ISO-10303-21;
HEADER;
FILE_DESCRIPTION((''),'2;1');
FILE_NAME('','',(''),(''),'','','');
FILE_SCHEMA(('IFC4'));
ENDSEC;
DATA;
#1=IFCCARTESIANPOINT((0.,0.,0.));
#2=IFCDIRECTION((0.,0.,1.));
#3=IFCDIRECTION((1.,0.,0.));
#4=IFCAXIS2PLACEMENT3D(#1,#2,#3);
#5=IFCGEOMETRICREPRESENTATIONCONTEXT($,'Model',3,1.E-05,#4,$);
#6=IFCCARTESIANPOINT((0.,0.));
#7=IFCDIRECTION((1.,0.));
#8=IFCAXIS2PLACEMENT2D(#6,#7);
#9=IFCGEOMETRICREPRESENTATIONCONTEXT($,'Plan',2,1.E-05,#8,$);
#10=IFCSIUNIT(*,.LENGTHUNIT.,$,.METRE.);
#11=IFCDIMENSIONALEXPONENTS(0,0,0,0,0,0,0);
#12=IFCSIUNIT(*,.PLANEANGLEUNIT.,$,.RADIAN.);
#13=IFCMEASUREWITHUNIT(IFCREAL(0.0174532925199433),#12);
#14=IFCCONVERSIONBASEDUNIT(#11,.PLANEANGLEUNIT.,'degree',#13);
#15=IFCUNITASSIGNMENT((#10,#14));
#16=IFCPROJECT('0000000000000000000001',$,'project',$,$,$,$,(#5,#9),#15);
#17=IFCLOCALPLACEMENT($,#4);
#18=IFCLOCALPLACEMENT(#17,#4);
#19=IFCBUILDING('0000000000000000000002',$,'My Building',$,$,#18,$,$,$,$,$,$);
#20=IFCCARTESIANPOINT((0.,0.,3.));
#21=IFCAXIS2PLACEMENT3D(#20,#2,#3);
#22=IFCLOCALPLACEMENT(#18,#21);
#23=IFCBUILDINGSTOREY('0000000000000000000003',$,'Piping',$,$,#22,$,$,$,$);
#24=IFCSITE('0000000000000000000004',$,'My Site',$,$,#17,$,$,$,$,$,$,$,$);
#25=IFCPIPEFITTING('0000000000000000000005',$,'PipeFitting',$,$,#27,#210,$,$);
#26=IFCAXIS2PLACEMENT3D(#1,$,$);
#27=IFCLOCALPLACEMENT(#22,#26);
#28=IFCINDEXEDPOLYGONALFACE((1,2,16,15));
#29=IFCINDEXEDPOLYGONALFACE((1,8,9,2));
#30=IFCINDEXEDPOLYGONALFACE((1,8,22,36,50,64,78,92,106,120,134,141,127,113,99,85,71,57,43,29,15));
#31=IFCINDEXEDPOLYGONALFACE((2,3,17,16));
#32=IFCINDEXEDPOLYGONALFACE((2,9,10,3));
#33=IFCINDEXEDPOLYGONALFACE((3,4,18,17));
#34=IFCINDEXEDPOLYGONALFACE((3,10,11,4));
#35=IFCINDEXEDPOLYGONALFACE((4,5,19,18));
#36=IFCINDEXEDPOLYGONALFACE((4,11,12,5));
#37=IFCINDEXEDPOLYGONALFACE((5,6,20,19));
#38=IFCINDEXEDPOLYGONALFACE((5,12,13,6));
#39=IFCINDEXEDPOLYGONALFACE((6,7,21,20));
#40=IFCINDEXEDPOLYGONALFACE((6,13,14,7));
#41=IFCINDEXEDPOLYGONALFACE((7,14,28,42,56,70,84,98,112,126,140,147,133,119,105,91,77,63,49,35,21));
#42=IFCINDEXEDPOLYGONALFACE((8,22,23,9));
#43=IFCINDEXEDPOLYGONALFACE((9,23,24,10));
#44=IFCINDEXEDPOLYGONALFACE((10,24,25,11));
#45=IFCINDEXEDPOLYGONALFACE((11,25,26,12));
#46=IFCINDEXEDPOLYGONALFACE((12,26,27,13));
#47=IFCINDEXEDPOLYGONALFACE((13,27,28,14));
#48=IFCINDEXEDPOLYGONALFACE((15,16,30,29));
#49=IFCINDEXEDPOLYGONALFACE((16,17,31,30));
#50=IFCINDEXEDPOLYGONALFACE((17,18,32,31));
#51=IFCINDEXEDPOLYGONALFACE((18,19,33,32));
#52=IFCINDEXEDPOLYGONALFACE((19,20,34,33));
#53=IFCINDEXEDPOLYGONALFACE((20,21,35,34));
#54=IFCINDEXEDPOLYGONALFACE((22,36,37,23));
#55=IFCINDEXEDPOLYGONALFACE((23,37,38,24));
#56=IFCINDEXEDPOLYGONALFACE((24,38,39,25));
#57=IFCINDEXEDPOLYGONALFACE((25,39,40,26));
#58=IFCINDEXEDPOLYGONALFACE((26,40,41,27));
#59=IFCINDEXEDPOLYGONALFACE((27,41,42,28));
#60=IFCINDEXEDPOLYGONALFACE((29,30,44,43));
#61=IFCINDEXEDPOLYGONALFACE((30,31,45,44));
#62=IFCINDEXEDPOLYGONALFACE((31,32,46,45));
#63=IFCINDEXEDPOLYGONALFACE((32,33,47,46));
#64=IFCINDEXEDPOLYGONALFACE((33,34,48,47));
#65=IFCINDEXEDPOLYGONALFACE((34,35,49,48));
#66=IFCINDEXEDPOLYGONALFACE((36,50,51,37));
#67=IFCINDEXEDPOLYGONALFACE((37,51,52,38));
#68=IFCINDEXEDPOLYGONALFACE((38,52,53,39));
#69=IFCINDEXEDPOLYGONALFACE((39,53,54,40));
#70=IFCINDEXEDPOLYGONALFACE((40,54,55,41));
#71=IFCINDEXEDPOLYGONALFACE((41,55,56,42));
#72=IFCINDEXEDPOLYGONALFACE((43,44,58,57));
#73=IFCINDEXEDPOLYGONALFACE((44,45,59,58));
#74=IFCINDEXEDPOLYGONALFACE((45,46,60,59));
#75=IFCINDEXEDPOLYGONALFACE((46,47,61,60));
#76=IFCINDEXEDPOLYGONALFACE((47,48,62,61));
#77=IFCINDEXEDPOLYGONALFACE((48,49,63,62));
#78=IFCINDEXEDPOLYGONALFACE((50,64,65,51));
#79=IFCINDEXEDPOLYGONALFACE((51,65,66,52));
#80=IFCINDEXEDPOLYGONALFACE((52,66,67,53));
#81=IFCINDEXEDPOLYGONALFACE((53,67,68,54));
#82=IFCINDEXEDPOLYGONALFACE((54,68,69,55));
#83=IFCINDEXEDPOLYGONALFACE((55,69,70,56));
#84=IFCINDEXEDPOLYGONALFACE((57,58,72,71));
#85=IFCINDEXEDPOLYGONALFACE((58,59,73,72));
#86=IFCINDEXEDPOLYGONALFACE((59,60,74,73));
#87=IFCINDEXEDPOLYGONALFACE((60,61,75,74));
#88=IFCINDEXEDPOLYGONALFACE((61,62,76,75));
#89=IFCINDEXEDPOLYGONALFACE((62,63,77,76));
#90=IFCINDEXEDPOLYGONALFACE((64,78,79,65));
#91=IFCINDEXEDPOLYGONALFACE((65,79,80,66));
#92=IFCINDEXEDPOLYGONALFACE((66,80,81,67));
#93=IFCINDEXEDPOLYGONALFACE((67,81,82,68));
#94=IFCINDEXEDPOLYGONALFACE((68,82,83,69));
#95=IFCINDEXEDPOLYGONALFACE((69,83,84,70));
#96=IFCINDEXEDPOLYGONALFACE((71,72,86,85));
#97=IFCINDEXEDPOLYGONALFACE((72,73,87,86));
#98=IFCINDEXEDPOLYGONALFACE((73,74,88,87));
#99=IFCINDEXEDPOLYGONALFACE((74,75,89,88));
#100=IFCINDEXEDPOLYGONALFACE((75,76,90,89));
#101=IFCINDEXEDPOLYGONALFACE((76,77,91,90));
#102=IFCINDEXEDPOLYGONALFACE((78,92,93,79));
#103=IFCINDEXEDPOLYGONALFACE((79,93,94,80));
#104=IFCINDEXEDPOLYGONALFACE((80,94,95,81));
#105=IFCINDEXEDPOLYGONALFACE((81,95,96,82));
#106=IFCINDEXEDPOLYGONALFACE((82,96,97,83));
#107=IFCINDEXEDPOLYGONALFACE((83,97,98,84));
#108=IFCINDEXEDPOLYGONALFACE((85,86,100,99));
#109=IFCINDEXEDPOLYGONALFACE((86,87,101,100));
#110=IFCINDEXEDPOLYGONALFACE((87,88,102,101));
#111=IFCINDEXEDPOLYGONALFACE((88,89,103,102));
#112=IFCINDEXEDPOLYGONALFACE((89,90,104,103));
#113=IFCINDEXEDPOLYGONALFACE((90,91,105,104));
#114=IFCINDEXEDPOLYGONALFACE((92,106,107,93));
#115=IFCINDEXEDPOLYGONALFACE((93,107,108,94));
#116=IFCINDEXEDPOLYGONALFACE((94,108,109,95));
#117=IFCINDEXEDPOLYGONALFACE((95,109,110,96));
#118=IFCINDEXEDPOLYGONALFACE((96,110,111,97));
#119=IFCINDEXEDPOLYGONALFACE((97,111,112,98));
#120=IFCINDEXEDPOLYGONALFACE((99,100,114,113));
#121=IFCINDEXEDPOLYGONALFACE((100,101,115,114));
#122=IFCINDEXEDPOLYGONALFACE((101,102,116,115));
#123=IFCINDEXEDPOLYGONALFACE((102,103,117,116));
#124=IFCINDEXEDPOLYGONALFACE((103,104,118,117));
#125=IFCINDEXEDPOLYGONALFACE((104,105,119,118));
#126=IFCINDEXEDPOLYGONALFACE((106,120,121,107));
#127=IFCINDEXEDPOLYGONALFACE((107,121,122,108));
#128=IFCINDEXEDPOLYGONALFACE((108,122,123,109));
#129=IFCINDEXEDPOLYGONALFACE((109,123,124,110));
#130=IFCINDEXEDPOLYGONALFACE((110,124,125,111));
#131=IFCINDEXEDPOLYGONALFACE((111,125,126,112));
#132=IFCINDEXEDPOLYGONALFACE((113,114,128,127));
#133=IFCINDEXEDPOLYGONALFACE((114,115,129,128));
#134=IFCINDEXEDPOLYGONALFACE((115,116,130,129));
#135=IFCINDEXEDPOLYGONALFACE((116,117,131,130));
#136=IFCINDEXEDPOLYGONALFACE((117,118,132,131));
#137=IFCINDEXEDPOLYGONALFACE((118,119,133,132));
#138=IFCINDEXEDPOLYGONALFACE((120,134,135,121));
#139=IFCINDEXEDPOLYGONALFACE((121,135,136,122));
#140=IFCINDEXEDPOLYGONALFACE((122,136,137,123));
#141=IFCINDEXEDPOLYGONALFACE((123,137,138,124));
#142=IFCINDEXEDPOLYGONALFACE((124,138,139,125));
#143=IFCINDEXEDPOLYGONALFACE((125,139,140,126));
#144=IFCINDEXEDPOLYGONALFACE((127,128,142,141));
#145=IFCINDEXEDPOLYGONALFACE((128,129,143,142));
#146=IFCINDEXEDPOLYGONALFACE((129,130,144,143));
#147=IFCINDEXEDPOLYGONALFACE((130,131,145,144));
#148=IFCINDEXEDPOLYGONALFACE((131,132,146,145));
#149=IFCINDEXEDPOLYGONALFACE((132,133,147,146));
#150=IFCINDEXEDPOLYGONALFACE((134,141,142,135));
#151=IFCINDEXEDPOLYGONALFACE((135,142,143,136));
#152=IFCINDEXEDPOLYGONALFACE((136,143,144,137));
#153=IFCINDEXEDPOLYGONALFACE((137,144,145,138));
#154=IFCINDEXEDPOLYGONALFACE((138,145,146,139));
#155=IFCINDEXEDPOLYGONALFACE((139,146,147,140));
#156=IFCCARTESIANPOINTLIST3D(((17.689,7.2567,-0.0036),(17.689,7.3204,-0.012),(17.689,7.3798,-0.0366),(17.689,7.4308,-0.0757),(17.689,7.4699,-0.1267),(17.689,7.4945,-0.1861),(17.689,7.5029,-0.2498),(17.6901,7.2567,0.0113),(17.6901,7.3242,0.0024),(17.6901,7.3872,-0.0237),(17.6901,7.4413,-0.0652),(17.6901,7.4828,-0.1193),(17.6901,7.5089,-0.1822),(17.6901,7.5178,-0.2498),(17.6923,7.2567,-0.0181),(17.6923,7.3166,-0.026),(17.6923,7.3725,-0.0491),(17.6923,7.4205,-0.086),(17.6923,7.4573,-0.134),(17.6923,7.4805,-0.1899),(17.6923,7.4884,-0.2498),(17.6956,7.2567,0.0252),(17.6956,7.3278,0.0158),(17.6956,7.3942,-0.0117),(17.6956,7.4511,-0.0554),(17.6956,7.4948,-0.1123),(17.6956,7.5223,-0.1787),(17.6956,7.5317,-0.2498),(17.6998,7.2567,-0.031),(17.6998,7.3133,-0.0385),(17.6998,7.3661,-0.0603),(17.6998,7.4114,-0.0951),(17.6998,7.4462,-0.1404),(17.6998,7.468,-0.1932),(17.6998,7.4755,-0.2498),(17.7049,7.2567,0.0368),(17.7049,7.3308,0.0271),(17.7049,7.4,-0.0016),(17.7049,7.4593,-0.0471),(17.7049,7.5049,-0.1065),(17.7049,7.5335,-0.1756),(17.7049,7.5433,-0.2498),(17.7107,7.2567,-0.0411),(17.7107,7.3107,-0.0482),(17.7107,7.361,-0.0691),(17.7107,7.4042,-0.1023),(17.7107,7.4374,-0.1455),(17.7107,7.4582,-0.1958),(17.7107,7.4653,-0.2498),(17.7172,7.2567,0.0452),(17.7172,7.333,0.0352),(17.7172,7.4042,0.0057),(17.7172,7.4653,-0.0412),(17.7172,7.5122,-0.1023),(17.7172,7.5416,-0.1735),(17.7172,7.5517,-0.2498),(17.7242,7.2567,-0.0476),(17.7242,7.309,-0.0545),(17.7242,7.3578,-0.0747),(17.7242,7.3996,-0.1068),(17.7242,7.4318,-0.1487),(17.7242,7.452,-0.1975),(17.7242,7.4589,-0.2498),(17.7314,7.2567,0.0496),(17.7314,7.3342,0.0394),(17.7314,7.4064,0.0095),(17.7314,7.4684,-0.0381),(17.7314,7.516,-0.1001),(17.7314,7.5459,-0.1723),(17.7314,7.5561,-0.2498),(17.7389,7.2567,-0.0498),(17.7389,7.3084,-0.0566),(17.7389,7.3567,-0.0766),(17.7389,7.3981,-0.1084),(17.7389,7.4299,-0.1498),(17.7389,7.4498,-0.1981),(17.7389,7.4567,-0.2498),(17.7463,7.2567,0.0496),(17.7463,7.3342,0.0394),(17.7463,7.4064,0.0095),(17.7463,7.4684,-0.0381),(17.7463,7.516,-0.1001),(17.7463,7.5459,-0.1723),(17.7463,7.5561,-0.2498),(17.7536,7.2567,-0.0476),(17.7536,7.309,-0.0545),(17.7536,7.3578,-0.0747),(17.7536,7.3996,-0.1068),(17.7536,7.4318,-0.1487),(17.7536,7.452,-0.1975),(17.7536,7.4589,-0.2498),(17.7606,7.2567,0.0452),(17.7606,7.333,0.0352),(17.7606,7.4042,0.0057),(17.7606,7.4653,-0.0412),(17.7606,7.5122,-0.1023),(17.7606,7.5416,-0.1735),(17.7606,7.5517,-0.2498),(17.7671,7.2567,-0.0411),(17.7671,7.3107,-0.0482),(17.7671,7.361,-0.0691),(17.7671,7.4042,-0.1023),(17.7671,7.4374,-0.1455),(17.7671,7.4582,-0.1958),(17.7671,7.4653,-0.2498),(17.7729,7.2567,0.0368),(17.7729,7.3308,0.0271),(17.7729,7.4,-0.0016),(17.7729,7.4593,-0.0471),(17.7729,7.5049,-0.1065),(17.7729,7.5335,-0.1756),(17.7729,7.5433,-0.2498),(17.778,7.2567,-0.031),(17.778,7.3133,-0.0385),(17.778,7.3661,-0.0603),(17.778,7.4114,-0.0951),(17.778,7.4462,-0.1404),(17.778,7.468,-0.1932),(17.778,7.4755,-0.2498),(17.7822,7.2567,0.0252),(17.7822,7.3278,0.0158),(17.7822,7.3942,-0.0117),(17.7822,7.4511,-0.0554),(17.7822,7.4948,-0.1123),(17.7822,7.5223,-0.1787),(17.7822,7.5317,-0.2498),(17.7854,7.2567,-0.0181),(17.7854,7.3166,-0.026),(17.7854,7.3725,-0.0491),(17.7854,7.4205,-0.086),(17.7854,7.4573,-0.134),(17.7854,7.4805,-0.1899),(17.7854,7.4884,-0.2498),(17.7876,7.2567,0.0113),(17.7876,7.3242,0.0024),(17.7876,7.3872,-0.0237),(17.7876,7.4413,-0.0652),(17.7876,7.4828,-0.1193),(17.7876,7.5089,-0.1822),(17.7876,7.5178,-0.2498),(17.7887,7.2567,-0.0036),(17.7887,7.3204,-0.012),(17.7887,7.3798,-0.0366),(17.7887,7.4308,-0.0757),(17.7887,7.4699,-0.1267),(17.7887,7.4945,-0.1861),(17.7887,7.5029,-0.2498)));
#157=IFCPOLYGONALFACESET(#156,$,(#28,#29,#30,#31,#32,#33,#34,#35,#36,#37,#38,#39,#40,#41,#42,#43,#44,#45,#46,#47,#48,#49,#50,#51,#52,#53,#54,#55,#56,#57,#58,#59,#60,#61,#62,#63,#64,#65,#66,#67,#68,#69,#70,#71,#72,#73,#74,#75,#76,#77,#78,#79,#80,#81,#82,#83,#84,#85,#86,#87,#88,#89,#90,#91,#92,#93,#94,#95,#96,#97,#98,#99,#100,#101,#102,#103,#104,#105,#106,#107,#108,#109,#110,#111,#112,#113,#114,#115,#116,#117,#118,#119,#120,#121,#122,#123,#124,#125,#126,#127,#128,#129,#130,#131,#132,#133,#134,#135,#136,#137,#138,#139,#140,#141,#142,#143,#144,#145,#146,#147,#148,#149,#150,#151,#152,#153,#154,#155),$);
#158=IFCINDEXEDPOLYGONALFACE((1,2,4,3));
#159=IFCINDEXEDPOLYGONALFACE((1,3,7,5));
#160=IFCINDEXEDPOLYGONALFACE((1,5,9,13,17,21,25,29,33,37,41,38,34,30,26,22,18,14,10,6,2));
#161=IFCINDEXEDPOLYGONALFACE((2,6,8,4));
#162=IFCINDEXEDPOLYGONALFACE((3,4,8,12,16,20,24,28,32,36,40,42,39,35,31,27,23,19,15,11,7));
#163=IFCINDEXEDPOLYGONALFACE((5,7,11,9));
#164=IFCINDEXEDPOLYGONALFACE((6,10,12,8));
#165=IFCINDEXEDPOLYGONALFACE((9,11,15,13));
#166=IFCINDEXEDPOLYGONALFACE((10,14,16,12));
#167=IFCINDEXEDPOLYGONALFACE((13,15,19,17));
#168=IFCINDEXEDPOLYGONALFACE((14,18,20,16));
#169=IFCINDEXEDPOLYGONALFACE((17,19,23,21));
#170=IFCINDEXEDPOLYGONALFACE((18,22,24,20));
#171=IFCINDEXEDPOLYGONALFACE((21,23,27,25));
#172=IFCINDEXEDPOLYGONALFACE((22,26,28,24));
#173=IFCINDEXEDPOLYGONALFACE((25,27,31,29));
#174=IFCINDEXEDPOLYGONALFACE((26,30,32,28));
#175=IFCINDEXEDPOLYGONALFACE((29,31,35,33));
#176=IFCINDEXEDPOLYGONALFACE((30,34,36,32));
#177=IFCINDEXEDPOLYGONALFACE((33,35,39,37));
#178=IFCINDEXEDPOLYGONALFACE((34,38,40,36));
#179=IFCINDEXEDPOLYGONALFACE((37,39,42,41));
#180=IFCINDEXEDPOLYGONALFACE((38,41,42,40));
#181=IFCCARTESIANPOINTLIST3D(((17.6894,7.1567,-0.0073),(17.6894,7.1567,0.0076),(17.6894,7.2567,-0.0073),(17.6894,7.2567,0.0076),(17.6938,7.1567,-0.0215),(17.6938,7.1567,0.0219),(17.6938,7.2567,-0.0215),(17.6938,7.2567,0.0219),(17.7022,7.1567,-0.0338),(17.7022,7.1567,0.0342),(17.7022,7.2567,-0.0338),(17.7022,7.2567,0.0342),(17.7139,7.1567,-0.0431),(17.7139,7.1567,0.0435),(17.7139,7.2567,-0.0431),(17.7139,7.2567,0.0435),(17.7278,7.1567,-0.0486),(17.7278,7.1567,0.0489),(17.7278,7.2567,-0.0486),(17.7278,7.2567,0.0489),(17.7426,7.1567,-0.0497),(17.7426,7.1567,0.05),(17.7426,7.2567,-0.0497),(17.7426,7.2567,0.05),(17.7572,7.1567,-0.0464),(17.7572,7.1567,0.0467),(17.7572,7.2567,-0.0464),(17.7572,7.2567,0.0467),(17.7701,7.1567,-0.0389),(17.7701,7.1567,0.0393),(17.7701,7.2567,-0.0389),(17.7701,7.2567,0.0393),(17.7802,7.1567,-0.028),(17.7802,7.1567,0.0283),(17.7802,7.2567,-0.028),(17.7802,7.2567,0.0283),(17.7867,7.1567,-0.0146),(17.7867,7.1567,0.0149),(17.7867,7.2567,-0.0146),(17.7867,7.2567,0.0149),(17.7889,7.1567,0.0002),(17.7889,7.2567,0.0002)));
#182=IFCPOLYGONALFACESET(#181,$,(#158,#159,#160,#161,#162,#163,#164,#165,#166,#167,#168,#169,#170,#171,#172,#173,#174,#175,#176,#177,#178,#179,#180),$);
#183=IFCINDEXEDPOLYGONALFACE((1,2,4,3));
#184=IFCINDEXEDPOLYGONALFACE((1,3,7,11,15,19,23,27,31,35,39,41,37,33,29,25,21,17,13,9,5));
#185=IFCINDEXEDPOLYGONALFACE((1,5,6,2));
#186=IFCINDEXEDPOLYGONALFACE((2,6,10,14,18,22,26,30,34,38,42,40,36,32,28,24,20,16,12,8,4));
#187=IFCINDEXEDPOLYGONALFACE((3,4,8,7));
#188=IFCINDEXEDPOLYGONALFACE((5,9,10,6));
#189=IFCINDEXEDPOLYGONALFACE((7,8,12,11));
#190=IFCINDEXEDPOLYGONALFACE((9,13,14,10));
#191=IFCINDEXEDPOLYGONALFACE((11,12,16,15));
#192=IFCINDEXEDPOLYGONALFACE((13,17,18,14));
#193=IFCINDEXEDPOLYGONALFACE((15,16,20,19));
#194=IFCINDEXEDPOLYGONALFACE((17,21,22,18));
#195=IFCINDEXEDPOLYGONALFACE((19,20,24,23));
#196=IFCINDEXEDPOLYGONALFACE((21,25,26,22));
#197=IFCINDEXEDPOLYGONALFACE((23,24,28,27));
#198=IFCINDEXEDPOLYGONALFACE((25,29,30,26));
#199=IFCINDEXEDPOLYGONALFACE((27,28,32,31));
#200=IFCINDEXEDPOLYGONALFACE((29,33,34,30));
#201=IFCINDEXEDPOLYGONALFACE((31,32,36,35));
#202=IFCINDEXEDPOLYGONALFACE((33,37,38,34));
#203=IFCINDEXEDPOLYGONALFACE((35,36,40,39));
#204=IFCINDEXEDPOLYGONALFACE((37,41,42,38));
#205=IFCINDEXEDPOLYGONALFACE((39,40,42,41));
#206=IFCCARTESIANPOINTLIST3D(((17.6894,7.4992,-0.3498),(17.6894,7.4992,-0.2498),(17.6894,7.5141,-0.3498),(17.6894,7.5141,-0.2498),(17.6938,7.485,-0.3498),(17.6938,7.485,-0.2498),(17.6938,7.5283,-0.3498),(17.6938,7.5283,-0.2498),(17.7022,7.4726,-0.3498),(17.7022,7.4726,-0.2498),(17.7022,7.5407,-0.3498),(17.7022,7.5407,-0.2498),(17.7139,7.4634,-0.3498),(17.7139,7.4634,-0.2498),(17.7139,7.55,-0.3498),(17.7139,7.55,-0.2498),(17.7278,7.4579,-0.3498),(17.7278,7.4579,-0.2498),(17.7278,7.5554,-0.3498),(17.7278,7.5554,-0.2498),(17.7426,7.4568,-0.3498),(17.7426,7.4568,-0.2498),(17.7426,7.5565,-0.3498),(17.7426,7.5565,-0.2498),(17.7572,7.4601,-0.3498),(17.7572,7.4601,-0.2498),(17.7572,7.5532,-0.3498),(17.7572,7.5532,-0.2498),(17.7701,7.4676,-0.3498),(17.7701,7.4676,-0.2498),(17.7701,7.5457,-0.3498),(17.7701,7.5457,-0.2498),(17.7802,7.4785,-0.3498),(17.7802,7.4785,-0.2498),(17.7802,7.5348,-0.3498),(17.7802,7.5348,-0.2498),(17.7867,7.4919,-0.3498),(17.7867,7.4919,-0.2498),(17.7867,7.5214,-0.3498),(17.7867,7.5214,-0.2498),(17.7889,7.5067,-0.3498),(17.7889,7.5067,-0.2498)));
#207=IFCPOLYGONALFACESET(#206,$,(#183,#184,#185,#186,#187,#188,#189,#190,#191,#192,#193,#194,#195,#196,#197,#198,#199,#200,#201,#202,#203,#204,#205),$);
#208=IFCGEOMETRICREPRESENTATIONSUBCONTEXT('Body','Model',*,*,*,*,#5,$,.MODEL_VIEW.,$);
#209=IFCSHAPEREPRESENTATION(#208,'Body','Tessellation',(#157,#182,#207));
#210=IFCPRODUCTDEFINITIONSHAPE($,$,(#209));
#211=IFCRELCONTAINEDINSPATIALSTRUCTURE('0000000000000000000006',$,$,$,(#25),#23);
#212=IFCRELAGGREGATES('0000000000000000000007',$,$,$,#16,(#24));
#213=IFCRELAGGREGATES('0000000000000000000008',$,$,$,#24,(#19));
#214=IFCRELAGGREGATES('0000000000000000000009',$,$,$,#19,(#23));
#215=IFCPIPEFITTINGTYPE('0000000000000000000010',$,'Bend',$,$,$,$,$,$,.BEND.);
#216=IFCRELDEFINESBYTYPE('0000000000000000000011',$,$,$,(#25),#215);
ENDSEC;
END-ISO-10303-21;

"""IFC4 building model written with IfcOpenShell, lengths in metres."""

from ifc_helpers import new_model, entity, si_unit, converted_unit, frame, origin_with_axes, origin_2d_with_axis, place, context, subcontext, project, spatial, circle, extrude, source, transform, mapped, type_object, type_shapes, element, save


model = new_model("IFC4")

# Units and contexts
model_context = context("Model", 3, precision=1e-05, world=origin_with_axes())
plan_context = context("Plan", 2, precision=1e-05, world=origin_2d_with_axis())
body_context = subcontext(model_context, "Body", "Model", "MODEL_VIEW")
ifc_project = project(units=[si_unit("LENGTHUNIT", "METRE"), converted_unit("PLANEANGLEUNIT", "degree", entity("IfcReal", 0.0174532925199433), si_unit("PLANEANGLEUNIT", "RADIAN"), dimensions=[0, 0, 0, 0, 0, 0, 0])], contexts=[model_context, plan_context])

# Site, building, storey
site_placement = place(None, origin_with_axes())
site = spatial("IfcSite", under=ifc_project, at=site_placement, Name="My Site")
building_placement = place(site_placement, origin_with_axes())
building = spatial("IfcBuilding", under=site, at=building_placement, Name="My Building")
storey_placement = place(building_placement, frame((0.0, 0.0, 3.0), z_axis=(0.0, 0.0, 1.0), x_axis=(1.0, 0.0, 0.0)))
storey = spatial("IfcBuildingStorey", under=building, at=storey_placement, Name="Piping")

# Pipe fitting
pipe_fitting_type = type_object("IfcPipeFittingType", Name="Bend", PredefinedType="BEND")
shared_shape = source(origin_with_axes(), body_context, "Body", "SolidModel", [
    entity("IfcSweptDiskSolid", entity("IfcIndexedPolyCurve", entity("IfcCartesianPointList3D", [[0.0, 0.0, -0.1], [0.0, -0.0732, -0.2768], [0.0, -0.25, -0.35]]), [entity("IfcArcIndex", [1, 2, 3])]), 0.05),
    extrude(circle(Radius=0.05), origin_with_axes(), (0.0, 0.0, -1.0), 0.1),
    extrude(circle(Radius=0.05), frame((0.0, -0.25, -0.35), z_axis=(0.0, -1.0, 0.0), x_axis=(1.0, 0.0, 0.0)), (0.0, 0.0, 1.0), 0.1),
])
type_shapes(pipe_fitting_type, [shared_shape])
for number, where, z_axis, x_axis, name in (
    (1, (17.7389, 7.1567, 0.0002), (0.0, -1.0, 0.0), (1.0, 0.0, 0.0), "PipeFitting"),
):
    element("IfcPipeFitting", number, at=place(storey_placement, frame(where, z_axis=z_axis, x_axis=x_axis)), inside=storey, type_object=pipe_fitting_type, Name=name, context=body_context, shape_type="MappedRepresentation", body=[
        mapped(shared_shape, transform((0.0, 0.0, 0.0), x_axis=(1.0, 0.0, 0.0), y_axis=(0.0, 1.0, 0.0), z_axis=(0.0, 0.0, 1.0), scale=1.0)),
    ])

save(model, "model.ifc")
